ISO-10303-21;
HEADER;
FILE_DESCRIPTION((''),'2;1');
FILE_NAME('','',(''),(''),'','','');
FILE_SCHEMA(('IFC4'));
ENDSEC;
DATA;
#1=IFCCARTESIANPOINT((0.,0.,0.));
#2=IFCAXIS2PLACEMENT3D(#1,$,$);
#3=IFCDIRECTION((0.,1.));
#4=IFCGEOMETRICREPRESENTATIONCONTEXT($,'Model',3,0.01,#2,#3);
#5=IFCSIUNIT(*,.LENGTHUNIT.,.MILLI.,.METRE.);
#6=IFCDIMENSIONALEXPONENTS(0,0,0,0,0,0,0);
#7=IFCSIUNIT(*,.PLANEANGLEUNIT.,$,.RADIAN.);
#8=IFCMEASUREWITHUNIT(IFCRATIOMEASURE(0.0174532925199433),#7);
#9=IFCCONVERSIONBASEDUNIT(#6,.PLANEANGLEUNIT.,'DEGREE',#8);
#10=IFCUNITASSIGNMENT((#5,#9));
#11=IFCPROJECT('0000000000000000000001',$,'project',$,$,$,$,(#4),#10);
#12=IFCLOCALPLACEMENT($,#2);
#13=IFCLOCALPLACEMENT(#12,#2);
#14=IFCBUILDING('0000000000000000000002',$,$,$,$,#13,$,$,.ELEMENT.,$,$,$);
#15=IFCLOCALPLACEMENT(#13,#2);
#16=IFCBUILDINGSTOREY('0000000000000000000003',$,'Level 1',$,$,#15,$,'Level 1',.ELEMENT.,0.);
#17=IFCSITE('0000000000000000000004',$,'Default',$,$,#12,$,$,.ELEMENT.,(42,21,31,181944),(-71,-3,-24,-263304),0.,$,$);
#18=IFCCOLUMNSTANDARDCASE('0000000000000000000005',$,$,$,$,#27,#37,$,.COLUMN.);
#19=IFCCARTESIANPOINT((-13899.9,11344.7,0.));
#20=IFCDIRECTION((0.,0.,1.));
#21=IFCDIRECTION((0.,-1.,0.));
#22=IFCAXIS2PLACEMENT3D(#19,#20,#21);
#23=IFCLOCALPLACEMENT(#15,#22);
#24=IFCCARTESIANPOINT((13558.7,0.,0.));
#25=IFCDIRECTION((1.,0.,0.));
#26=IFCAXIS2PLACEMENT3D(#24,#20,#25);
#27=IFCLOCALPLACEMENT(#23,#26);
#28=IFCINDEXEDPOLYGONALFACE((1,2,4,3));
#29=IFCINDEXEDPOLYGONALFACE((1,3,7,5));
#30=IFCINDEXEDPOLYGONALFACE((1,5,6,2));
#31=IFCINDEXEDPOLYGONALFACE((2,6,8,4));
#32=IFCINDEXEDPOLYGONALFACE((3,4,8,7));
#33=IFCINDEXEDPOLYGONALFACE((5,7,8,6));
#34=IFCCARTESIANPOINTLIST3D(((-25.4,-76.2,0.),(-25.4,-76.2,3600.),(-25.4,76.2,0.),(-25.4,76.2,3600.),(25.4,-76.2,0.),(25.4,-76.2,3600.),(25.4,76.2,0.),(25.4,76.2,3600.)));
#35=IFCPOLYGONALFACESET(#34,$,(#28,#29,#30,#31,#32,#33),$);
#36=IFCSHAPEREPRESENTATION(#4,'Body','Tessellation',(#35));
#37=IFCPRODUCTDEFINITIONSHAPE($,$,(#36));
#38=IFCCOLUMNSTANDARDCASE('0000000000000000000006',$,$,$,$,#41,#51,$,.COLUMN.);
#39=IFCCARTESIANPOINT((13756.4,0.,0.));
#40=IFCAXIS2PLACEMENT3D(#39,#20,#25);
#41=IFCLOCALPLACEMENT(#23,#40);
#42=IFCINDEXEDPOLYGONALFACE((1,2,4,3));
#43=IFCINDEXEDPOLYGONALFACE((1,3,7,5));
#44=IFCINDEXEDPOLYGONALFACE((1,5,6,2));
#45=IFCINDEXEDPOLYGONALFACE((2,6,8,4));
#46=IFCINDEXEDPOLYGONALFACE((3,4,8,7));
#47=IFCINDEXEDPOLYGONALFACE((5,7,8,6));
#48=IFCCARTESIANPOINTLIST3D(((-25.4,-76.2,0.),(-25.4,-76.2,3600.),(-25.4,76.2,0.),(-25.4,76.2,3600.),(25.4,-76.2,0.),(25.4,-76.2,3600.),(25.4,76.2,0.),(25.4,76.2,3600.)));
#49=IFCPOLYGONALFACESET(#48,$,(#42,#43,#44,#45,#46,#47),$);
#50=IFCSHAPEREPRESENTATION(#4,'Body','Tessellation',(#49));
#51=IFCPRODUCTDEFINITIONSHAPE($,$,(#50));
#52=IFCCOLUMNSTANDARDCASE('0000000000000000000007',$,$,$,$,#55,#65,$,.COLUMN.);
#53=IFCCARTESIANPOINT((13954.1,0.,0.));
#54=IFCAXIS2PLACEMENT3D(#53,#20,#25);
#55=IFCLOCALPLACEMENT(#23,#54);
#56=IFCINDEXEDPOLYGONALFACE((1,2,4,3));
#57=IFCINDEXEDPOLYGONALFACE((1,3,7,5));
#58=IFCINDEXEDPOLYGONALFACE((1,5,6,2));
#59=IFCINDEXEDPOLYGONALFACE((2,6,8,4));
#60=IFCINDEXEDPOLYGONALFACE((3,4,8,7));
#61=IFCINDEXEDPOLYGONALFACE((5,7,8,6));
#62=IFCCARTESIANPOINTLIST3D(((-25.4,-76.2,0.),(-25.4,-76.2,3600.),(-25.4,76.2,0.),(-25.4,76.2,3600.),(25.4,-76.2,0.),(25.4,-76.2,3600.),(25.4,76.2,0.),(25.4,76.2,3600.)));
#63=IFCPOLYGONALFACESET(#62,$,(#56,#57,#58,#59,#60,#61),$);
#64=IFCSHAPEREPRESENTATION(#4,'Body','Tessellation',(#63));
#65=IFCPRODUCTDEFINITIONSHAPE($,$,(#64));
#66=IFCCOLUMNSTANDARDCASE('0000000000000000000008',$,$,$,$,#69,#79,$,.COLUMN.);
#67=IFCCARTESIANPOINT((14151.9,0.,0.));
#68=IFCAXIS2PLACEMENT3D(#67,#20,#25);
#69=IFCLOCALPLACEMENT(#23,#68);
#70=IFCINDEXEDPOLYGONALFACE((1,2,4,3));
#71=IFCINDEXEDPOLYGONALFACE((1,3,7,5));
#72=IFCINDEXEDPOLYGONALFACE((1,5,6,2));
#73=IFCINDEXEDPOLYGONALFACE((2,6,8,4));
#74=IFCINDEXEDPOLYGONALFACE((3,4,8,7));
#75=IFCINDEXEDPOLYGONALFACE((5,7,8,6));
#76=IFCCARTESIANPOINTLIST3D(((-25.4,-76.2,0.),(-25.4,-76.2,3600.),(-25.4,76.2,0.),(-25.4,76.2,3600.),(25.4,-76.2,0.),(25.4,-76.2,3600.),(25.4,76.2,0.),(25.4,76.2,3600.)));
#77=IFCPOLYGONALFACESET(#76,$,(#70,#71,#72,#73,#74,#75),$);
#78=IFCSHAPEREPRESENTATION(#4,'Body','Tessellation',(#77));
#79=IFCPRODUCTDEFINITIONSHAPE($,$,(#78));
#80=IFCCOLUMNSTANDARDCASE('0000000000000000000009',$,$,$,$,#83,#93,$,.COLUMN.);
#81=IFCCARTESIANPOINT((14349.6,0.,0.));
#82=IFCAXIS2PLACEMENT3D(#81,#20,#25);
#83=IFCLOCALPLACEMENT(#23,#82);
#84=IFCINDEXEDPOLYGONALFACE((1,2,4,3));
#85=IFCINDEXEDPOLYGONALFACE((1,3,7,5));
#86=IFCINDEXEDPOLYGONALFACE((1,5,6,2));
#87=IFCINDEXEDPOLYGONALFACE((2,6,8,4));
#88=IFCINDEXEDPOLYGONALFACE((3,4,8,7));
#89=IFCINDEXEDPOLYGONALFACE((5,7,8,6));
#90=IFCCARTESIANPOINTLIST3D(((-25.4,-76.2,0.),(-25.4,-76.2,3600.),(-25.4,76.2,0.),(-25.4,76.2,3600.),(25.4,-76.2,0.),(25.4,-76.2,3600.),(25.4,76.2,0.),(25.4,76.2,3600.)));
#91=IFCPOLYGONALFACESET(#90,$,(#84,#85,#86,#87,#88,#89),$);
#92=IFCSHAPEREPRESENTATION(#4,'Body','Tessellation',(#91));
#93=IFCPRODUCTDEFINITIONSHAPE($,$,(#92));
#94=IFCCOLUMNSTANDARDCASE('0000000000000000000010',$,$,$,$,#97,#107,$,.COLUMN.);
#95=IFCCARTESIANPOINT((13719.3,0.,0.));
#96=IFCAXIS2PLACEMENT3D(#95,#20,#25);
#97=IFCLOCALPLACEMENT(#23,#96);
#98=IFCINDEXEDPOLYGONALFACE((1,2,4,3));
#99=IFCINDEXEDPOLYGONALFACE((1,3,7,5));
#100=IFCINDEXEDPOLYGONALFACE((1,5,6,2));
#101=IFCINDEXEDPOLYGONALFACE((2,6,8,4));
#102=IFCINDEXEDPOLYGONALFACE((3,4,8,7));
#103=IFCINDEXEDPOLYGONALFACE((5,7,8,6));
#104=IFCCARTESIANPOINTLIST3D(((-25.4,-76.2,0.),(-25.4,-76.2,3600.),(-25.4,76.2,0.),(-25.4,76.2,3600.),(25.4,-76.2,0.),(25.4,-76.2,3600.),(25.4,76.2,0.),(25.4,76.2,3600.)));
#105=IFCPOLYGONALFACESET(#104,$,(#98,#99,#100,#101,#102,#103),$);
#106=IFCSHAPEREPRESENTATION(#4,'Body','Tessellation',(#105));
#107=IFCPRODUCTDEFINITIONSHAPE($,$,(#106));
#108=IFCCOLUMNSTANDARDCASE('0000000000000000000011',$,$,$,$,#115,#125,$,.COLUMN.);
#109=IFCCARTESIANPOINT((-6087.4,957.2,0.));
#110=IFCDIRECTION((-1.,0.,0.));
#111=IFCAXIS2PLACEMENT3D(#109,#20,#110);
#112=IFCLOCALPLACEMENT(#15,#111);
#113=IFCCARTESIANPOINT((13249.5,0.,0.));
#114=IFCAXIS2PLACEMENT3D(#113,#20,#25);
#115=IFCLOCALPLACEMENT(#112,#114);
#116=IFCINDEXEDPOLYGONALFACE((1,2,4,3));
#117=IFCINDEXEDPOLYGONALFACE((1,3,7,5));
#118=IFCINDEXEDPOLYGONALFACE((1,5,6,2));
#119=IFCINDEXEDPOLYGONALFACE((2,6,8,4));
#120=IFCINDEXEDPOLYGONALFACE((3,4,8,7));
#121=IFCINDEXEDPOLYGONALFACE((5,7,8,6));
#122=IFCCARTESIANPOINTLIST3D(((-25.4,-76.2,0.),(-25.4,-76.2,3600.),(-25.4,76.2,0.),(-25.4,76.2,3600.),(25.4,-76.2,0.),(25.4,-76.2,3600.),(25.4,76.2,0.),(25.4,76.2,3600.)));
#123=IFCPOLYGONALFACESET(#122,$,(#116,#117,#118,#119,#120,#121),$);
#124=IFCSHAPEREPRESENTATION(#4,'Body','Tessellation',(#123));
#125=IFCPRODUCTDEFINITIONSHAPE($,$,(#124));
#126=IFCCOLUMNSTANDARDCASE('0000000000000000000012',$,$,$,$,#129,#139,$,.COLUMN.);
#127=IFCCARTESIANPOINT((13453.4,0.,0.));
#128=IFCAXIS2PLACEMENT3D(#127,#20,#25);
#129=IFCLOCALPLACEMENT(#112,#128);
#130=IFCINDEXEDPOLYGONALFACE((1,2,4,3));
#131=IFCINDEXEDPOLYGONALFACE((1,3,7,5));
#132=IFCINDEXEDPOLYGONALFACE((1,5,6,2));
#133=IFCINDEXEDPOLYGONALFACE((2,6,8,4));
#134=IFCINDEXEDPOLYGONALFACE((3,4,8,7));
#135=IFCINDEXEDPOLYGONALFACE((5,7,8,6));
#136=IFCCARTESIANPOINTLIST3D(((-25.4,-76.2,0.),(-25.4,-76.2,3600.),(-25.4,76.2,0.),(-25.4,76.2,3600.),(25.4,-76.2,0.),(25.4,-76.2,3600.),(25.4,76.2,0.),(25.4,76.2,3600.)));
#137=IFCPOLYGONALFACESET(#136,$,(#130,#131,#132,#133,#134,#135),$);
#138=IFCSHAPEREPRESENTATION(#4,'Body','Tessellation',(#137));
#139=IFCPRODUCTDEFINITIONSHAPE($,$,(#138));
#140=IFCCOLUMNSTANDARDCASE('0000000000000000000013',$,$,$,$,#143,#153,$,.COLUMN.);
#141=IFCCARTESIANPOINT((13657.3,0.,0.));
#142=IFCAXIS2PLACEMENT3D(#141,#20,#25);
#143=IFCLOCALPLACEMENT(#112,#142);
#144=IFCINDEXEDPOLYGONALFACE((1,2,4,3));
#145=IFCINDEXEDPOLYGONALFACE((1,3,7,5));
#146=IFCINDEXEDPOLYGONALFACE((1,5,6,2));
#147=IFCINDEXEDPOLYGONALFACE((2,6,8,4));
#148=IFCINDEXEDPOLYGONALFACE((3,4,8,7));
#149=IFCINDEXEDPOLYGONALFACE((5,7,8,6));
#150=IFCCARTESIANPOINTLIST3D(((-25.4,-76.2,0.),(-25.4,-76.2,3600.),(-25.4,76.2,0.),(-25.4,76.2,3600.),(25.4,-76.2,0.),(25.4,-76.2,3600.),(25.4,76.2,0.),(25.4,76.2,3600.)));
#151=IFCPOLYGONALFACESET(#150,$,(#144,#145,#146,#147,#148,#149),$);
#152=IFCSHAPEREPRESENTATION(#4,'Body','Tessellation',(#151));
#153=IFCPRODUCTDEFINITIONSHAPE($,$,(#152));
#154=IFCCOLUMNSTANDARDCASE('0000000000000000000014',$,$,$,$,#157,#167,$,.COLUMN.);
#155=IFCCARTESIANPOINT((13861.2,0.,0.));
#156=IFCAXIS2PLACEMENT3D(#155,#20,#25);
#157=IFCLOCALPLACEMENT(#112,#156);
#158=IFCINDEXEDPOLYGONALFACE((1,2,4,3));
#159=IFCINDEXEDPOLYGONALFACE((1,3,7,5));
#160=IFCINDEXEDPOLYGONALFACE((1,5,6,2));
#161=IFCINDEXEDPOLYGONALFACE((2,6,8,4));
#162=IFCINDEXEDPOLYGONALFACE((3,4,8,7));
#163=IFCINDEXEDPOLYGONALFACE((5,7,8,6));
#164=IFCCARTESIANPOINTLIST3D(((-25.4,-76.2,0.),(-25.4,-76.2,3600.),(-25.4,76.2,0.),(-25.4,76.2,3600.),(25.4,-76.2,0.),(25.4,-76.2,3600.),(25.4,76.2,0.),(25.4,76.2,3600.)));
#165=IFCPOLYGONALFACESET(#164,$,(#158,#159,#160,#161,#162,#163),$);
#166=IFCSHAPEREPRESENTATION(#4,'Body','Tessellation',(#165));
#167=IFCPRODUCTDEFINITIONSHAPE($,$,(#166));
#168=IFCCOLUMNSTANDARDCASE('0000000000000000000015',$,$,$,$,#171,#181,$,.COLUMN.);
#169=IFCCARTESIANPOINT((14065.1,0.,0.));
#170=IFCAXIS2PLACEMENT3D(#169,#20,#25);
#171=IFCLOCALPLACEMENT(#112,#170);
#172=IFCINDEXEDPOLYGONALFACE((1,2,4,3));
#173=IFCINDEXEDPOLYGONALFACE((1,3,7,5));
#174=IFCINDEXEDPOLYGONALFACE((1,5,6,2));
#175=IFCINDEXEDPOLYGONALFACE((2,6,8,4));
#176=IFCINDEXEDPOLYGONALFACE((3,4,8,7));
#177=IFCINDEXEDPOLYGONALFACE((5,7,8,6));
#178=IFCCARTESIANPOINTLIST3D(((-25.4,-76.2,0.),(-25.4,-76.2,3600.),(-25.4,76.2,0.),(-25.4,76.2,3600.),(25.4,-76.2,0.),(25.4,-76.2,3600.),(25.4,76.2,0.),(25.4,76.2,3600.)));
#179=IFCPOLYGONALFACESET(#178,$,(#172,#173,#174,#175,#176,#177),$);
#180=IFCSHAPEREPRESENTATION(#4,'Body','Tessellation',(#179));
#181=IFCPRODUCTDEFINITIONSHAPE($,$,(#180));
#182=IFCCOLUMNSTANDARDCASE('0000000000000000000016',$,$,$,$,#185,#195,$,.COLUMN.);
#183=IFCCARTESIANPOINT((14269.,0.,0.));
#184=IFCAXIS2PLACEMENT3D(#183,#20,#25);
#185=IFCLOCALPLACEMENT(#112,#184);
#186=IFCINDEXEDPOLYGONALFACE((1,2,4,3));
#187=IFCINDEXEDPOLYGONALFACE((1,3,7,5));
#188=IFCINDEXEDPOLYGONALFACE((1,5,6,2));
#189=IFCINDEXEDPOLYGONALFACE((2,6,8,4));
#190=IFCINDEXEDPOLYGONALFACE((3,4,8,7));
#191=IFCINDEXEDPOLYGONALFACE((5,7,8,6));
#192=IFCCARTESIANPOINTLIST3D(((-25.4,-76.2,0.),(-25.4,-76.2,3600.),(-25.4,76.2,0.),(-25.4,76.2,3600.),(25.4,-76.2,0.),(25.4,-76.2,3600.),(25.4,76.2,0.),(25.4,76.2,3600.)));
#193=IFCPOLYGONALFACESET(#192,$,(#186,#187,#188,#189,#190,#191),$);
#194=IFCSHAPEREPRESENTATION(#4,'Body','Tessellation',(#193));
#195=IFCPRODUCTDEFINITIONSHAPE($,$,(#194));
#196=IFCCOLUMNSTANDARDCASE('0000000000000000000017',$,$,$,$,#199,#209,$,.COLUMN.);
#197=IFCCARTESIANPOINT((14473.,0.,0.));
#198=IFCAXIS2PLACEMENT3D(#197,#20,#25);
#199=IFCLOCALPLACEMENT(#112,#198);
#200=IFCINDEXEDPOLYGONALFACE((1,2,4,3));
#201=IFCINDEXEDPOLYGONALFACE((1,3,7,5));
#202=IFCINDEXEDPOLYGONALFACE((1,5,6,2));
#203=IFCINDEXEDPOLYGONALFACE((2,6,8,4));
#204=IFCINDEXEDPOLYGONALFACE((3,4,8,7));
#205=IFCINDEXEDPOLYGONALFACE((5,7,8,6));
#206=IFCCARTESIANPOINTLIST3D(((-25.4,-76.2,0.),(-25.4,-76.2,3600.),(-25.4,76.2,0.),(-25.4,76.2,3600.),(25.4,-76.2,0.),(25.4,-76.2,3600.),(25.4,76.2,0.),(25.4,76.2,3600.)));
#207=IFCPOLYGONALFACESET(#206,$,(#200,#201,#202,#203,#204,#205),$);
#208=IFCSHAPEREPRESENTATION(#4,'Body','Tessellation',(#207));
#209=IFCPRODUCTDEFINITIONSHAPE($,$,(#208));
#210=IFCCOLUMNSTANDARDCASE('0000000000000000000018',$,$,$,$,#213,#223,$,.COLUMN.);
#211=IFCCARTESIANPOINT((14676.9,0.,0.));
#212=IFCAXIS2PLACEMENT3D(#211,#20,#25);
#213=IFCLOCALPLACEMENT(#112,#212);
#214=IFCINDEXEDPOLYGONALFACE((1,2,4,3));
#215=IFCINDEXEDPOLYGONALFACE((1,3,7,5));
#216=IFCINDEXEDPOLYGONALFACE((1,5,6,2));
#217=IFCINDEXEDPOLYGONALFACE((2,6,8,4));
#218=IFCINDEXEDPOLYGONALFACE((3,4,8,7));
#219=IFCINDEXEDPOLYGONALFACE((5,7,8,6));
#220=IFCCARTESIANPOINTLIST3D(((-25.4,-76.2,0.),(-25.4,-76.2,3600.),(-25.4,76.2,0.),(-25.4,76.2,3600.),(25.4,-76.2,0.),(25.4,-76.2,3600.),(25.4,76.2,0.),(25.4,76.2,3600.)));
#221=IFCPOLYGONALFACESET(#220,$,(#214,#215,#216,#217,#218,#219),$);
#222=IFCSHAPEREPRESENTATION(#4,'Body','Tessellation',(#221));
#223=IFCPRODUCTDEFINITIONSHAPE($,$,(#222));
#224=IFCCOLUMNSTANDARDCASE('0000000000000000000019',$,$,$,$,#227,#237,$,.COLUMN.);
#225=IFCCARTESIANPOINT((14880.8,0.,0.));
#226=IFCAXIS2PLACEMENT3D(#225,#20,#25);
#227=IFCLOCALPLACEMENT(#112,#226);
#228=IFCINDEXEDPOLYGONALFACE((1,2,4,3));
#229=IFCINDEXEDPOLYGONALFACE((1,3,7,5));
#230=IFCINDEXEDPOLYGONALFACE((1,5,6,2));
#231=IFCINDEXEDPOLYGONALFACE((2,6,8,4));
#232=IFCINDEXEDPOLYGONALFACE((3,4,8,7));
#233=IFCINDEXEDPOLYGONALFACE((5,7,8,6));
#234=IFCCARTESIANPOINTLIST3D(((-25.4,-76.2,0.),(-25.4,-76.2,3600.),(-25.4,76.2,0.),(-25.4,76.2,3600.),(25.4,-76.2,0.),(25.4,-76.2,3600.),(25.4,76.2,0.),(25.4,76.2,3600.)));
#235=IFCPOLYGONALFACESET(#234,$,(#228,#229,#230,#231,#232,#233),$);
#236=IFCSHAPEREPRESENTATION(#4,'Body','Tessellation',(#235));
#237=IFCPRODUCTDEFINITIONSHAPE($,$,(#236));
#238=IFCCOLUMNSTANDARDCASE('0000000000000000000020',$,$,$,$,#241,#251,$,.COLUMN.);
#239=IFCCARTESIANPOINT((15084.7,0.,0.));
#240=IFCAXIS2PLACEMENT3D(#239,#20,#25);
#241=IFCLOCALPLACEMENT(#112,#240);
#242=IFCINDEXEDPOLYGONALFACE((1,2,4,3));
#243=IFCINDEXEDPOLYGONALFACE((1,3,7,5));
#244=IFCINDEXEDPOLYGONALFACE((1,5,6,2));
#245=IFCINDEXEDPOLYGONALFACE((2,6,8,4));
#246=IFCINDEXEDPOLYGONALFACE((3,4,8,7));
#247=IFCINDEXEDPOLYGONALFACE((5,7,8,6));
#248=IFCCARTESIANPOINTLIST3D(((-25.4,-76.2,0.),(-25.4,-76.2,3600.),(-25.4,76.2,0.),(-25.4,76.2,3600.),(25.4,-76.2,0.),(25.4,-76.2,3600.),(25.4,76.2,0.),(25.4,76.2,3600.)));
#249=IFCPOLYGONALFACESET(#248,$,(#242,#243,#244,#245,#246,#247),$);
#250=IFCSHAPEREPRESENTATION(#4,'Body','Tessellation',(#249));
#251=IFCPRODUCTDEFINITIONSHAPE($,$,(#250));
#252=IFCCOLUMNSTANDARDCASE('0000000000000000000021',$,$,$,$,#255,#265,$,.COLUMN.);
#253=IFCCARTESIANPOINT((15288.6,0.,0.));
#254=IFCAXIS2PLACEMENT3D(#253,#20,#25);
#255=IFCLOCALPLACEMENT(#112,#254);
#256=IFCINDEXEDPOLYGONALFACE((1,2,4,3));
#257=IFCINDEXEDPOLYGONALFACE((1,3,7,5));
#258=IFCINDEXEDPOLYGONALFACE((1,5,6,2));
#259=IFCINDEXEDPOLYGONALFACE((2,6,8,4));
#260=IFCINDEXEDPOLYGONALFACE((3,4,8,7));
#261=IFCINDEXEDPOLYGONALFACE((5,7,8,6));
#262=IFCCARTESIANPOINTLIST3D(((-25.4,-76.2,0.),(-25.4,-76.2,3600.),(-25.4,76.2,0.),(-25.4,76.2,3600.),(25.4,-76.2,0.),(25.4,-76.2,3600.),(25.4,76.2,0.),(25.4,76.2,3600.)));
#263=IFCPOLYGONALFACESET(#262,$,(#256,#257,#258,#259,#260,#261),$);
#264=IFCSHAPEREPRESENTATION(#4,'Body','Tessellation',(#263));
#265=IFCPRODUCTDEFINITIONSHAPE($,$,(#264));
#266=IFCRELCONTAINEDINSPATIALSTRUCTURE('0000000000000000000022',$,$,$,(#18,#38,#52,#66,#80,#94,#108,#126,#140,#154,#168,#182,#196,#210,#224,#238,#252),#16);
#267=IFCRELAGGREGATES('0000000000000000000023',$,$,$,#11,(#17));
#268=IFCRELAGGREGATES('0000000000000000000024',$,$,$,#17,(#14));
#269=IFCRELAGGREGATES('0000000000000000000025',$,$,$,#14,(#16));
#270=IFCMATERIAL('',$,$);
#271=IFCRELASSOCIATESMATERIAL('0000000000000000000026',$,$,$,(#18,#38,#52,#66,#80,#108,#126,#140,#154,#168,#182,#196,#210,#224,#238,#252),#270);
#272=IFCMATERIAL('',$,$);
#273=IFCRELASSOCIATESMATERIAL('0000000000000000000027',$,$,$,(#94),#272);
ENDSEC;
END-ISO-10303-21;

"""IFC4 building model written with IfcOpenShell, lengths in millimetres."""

from ifc_helpers import new_model, entity, si_unit, converted_unit, direction, frame, origin, place, context, project, spatial, rectangle, extrude, material, element, save


model = new_model("IFC4")

# Units and contexts
model_context = context("Model", 3, precision=0.01, world=origin(), true_north=direction((0.0, 1.0)))
ifc_project = project(units=[si_unit("LENGTHUNIT", "METRE", prefix="MILLI"), converted_unit("PLANEANGLEUNIT", "DEGREE", entity("IfcRatioMeasure", 0.0174532925199433), si_unit("PLANEANGLEUNIT", "RADIAN"), dimensions=[0, 0, 0, 0, 0, 0, 0])], contexts=[model_context])

# Site, building, storey
site_placement = place(None, origin())
site = spatial("IfcSite", under=ifc_project, at=site_placement, Name="Default", CompositionType="ELEMENT", RefLatitude=(42, 21, 31, 181944), RefLongitude=(-71, -3, -24, -263304), RefElevation=0.0)
building_placement = place(site_placement, origin())
building = spatial("IfcBuilding", under=site, at=building_placement, CompositionType="ELEMENT")
storey_placement = place(building_placement, origin())
storey = spatial("IfcBuildingStorey", under=building, at=storey_placement, Name="Level 1", LongName="Level 1", CompositionType="ELEMENT", Elevation=0.0)

# Columns
ifc_material_1 = material(Name="")
placement_1 = place(storey_placement, frame((-13899.9, 11344.7, 0.0), z_axis=(0.0, 0.0, 1.0), x_axis=(0.0, -1.0, 0.0)))
for number, where, z_axis, x_axis in (
    (1, (13558.7, 0.0, 0.0), (0.0, 0.0, 1.0), (1.0, 0.0, 0.0)),
    (2, (13756.4, 0.0, 0.0), (0.0, 0.0, 1.0), (1.0, 0.0, 0.0)),
    (3, (13954.1, 0.0, 0.0), (0.0, 0.0, 1.0), (1.0, 0.0, 0.0)),
    (4, (14151.9, 0.0, 0.0), (0.0, 0.0, 1.0), (1.0, 0.0, 0.0)),
    (5, (14349.6, 0.0, 0.0), (0.0, 0.0, 1.0), (1.0, 0.0, 0.0)),
):
    element("IfcColumnStandardCase", number, at=place(placement_1, frame(where, z_axis=z_axis, x_axis=x_axis)), inside=storey, material=ifc_material_1, PredefinedType="COLUMN", context=model_context, shape_type="SweptSolid", body=[
        extrude(rectangle(XDim=50.8, YDim=152.4), origin(), (0.0, 0.0, 1.0), 3600.0),
    ])
ifc_material_2 = material(Name="")
for number, where, z_axis, x_axis in (
    (6, (13719.3, 0.0, 0.0), (0.0, 0.0, 1.0), (1.0, 0.0, 0.0)),
):
    element("IfcColumnStandardCase", number, at=place(placement_1, frame(where, z_axis=z_axis, x_axis=x_axis)), inside=storey, material=ifc_material_2, PredefinedType="COLUMN", context=model_context, shape_type="SweptSolid", body=[
        extrude(rectangle(XDim=50.8, YDim=152.4), origin(), (0.0, 0.0, 1.0), 3600.0),
    ])
placement_2 = place(storey_placement, frame((-6087.4, 957.2, 0.0), z_axis=(0.0, 0.0, 1.0), x_axis=(-1.0, 0.0, 0.0)))
for number, where, z_axis, x_axis in (
    (7, (13249.5, 0.0, 0.0), (0.0, 0.0, 1.0), (1.0, 0.0, 0.0)),
    (8, (13453.4, 0.0, 0.0), (0.0, 0.0, 1.0), (1.0, 0.0, 0.0)),
    (9, (13657.3, 0.0, 0.0), (0.0, 0.0, 1.0), (1.0, 0.0, 0.0)),
    (10, (13861.2, 0.0, 0.0), (0.0, 0.0, 1.0), (1.0, 0.0, 0.0)),
    (11, (14065.1, 0.0, 0.0), (0.0, 0.0, 1.0), (1.0, 0.0, 0.0)),
    (12, (14269.0, 0.0, 0.0), (0.0, 0.0, 1.0), (1.0, 0.0, 0.0)),
    (13, (14473.0, 0.0, 0.0), (0.0, 0.0, 1.0), (1.0, 0.0, 0.0)),
    (14, (14676.9, 0.0, 0.0), (0.0, 0.0, 1.0), (1.0, 0.0, 0.0)),
    (15, (14880.8, 0.0, 0.0), (0.0, 0.0, 1.0), (1.0, 0.0, 0.0)),
    (16, (15084.7, 0.0, 0.0), (0.0, 0.0, 1.0), (1.0, 0.0, 0.0)),
    (17, (15288.6, 0.0, 0.0), (0.0, 0.0, 1.0), (1.0, 0.0, 0.0)),
):
    element("IfcColumnStandardCase", number, at=place(placement_2, frame(where, z_axis=z_axis, x_axis=x_axis)), inside=storey, material=ifc_material_1, PredefinedType="COLUMN", context=model_context, shape_type="SweptSolid", body=[
        extrude(rectangle(XDim=50.8, YDim=152.4), origin(), (0.0, 0.0, 1.0), 3600.0),
    ])

save(model, "model.ifc")
